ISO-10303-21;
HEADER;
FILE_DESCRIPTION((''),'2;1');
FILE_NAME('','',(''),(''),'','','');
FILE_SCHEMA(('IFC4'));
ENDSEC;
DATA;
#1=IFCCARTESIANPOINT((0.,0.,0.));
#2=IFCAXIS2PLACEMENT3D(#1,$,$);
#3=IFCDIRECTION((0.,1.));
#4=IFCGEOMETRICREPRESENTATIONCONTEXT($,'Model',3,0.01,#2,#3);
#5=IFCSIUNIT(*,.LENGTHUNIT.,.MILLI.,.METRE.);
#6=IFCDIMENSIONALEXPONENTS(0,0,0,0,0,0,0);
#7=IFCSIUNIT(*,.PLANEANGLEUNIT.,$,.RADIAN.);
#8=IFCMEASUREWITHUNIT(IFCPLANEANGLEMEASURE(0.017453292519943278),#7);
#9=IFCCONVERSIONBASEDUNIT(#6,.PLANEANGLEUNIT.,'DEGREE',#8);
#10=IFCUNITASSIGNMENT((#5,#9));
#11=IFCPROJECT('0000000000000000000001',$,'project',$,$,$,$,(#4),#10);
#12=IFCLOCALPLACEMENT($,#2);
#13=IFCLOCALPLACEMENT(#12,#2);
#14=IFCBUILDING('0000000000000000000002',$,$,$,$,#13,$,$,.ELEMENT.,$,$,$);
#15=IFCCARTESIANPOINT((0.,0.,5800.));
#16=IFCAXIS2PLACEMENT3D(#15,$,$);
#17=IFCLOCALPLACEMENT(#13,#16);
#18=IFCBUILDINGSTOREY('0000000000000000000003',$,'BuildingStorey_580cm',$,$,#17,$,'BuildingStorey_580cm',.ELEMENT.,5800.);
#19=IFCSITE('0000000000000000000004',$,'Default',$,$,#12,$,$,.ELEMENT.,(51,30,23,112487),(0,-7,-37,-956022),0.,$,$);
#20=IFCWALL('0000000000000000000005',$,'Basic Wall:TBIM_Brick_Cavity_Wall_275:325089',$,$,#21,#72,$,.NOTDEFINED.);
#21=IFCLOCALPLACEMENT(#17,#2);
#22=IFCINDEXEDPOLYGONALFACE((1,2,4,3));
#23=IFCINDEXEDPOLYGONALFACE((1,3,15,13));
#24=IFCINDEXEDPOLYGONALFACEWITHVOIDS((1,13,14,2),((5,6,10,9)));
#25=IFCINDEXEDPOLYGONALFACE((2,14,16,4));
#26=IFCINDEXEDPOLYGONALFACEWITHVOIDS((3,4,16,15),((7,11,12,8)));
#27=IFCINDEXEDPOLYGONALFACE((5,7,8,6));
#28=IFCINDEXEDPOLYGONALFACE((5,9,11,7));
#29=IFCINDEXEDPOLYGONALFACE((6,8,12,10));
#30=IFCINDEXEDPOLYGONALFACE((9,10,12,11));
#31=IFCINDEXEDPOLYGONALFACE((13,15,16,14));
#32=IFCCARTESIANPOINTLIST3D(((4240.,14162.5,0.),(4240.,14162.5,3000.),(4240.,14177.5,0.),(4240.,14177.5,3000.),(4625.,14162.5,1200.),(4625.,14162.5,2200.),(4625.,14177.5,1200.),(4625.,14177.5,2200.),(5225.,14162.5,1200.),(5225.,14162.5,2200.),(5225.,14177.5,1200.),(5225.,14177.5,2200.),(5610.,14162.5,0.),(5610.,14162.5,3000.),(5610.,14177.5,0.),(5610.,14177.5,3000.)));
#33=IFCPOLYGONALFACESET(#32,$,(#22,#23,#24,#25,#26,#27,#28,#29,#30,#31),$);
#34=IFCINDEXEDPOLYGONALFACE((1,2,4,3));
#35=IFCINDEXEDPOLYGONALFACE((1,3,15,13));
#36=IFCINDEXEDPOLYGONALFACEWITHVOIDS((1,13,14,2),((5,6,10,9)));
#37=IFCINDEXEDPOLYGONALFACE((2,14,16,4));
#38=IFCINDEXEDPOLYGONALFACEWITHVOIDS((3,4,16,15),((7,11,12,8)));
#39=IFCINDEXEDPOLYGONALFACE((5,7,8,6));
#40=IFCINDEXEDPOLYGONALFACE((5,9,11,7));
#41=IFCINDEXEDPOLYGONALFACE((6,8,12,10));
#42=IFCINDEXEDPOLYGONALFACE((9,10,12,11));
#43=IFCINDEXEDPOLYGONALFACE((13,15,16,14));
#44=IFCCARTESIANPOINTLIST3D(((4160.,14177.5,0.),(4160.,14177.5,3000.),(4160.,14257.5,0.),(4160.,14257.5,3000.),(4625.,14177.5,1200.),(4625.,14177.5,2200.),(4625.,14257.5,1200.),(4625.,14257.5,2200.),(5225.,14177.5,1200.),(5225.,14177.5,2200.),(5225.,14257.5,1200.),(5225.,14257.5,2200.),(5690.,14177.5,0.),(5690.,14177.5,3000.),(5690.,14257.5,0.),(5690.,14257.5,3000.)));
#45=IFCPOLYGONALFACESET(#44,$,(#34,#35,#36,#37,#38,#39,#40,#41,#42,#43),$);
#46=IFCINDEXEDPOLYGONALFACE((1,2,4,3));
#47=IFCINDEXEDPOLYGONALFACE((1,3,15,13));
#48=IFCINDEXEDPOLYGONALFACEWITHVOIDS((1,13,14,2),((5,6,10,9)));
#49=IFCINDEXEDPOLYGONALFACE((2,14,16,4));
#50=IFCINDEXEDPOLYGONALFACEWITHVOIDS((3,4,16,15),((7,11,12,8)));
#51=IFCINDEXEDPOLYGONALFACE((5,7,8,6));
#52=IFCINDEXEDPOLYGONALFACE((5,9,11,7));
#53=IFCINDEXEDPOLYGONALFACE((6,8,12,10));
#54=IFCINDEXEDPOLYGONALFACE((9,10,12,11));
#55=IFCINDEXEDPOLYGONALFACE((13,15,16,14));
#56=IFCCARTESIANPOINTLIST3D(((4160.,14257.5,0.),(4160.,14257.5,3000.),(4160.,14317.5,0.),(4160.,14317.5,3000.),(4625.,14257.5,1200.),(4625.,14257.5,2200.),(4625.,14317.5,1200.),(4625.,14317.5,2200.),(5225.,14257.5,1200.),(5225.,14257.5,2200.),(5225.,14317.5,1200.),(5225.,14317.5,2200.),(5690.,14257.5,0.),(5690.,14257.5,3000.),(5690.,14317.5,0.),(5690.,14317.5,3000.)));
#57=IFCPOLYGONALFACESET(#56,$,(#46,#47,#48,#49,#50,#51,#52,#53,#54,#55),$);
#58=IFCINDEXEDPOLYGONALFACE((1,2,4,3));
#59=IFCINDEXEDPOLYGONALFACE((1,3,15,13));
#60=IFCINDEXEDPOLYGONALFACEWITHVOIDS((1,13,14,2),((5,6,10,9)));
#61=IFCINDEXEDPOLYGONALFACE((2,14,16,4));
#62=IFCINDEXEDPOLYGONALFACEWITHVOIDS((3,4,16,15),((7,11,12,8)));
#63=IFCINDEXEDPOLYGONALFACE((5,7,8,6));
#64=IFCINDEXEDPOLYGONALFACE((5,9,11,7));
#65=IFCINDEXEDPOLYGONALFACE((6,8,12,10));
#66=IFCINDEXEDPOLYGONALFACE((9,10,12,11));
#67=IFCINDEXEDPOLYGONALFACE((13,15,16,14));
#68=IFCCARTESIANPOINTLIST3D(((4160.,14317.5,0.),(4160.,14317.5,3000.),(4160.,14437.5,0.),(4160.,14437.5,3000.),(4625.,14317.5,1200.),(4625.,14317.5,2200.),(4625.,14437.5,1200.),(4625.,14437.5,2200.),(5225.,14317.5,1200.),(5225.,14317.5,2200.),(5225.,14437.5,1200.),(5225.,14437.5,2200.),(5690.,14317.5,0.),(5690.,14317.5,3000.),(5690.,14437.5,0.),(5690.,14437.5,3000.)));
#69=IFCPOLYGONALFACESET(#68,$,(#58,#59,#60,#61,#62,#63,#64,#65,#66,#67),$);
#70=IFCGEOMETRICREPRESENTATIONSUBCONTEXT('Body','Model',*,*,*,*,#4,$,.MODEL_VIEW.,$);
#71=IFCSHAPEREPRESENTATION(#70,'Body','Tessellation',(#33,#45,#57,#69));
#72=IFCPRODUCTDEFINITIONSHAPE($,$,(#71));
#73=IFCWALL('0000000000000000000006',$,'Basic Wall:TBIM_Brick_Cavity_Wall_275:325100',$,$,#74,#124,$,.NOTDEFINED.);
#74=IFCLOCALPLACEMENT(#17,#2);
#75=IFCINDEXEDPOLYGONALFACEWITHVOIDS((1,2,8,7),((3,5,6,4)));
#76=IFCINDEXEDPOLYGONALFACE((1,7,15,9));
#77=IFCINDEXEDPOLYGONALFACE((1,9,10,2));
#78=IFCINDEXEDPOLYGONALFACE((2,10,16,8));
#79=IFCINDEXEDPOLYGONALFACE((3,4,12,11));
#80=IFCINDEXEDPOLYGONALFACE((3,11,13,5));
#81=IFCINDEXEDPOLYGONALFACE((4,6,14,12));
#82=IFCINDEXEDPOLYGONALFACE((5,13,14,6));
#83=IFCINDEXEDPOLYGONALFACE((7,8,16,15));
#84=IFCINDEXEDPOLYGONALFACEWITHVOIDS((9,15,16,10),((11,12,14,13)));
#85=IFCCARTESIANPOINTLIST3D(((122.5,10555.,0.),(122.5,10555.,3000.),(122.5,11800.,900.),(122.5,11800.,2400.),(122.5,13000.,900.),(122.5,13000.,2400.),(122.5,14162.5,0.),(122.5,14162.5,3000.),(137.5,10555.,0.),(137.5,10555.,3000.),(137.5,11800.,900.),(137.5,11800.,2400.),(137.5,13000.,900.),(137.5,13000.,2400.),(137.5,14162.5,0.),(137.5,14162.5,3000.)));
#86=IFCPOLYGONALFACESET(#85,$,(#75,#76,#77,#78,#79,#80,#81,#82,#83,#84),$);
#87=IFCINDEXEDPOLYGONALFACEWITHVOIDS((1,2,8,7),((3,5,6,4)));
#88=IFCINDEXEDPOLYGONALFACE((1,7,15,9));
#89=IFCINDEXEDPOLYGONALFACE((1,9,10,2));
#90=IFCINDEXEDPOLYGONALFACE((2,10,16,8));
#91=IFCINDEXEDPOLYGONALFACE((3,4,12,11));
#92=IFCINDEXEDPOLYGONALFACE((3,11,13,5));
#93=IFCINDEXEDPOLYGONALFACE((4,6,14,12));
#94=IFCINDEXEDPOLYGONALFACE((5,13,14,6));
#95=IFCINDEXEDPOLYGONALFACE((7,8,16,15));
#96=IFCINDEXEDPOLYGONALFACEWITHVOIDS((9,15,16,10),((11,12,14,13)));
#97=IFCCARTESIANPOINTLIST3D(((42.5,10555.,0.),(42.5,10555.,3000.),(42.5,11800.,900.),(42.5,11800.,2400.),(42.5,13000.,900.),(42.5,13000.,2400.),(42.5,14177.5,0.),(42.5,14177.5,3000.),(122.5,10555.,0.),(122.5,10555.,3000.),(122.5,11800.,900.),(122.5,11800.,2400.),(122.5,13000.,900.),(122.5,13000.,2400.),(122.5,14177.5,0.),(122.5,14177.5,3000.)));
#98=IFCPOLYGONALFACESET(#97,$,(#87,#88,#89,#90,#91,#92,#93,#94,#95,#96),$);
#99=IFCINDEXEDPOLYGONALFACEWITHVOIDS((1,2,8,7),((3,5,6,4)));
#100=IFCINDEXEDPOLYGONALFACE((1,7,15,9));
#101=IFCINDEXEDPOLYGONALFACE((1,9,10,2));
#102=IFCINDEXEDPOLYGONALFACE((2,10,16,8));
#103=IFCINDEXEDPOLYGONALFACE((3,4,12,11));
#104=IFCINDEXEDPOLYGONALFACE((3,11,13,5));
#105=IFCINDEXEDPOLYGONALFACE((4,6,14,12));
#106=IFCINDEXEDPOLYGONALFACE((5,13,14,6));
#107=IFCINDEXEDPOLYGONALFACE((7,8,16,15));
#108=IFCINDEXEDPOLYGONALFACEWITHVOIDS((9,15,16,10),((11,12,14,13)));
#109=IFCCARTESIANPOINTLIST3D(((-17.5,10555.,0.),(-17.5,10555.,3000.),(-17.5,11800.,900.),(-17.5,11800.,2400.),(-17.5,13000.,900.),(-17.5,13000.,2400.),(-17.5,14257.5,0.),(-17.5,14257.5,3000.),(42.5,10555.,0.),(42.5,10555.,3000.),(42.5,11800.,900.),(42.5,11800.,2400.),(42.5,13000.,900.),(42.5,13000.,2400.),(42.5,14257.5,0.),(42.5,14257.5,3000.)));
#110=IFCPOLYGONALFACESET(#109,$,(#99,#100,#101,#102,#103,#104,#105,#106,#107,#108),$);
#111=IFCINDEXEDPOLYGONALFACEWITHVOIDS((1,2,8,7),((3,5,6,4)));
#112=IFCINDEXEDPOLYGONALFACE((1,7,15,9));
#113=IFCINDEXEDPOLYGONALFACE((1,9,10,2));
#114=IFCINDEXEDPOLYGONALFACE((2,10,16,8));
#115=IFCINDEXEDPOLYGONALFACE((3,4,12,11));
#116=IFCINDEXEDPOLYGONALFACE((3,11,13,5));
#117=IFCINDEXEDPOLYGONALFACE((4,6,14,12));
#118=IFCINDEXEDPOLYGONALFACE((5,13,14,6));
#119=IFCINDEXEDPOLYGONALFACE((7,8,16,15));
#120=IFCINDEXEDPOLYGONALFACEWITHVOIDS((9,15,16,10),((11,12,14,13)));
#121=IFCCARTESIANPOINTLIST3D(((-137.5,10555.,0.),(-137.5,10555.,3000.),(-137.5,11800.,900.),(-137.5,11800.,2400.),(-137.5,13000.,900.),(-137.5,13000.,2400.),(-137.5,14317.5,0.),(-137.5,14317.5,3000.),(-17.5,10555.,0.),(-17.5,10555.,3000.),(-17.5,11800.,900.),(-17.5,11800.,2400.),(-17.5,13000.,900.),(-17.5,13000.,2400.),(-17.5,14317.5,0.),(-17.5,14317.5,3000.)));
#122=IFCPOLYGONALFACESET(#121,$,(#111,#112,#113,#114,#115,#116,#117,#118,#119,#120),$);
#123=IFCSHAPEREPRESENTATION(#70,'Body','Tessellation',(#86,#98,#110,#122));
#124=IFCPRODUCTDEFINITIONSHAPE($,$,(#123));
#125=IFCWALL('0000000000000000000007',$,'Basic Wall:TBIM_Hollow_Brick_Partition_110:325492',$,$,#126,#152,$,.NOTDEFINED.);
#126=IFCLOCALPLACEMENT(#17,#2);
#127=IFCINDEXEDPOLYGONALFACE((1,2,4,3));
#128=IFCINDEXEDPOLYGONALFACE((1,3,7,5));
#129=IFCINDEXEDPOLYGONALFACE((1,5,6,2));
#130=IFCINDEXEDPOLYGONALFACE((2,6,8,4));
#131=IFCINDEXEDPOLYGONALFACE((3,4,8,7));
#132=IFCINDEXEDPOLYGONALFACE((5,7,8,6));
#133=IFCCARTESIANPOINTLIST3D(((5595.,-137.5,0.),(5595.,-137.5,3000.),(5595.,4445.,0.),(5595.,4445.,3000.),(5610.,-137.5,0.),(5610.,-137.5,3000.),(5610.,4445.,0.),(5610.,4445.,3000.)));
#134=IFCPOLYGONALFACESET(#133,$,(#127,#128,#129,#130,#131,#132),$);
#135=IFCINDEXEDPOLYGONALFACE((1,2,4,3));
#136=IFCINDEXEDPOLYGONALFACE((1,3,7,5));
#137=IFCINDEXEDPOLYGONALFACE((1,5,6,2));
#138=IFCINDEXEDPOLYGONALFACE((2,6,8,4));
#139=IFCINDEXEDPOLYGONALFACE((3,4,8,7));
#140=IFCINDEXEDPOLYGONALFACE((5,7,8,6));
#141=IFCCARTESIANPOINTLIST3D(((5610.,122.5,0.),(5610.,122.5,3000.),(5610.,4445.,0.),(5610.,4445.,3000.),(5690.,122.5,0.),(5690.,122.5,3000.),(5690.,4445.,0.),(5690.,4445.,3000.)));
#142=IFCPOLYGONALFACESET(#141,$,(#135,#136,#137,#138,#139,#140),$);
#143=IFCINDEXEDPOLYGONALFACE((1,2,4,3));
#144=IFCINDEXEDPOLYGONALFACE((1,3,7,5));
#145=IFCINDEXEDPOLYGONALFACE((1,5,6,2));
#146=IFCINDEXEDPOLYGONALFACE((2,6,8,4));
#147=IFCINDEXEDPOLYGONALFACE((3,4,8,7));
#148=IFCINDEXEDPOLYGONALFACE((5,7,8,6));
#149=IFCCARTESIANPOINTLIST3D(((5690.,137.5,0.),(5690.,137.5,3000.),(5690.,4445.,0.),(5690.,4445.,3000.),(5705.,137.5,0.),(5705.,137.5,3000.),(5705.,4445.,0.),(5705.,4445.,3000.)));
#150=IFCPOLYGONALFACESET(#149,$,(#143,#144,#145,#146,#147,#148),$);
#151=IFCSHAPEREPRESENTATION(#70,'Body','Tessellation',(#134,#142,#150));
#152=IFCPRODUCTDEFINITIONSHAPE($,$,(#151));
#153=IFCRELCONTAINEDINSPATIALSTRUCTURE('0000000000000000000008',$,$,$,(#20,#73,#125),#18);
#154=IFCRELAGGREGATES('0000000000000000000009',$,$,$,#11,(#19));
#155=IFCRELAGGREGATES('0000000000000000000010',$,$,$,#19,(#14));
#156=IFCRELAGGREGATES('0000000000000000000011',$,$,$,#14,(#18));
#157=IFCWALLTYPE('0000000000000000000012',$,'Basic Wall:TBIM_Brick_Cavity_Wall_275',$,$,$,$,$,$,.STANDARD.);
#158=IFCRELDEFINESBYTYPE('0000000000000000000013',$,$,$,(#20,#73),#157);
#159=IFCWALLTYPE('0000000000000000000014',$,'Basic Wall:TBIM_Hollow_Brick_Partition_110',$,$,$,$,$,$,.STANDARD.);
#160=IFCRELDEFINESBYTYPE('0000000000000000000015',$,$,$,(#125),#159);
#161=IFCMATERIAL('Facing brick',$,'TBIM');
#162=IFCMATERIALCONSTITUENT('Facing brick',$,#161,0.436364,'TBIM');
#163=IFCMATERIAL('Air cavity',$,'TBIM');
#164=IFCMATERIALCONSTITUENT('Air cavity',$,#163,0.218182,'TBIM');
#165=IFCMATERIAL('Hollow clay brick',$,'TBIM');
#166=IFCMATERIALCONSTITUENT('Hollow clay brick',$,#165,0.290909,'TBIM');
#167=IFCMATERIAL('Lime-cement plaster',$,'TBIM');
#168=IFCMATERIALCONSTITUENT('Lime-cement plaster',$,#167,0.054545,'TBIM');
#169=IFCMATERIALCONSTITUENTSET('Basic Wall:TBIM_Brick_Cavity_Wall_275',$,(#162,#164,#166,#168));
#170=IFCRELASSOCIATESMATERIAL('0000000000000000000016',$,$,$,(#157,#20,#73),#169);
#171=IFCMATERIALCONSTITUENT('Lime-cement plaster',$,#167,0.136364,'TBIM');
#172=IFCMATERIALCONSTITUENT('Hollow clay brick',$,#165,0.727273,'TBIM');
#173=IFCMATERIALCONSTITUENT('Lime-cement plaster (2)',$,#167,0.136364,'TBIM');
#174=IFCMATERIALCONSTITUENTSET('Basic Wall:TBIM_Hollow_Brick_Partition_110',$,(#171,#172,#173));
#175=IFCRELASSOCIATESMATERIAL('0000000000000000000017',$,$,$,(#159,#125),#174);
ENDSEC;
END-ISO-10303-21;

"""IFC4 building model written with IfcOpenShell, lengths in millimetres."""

from ifc_helpers import new_model, entity, si_unit, converted_unit, direction, frame, origin, place, context, subcontext, project, spatial, indexed_curve, outline, extrude, material, constituent, constituent_set, type_object, element, save


model = new_model("IFC4")

# Units and contexts
model_context = context("Model", 3, precision=0.01, world=origin(), true_north=direction((0.0, 1.0)))
body_context = subcontext(model_context, "Body", "Model", "MODEL_VIEW")
ifc_project = project(units=[si_unit("LENGTHUNIT", "METRE", prefix="MILLI"), converted_unit("PLANEANGLEUNIT", "DEGREE", entity("IfcPlaneAngleMeasure", 0.017453292519943278), si_unit("PLANEANGLEUNIT", "RADIAN"), dimensions=[0, 0, 0, 0, 0, 0, 0])], contexts=[model_context])

# Site, building, storey
site_placement = place(None, origin())
site = spatial("IfcSite", under=ifc_project, at=site_placement, Name="Default", CompositionType="ELEMENT", RefLatitude=(51, 30, 23, 112487), RefLongitude=(0, -7, -37, -956022), RefElevation=0.0)
building_placement = place(site_placement, origin())
building = spatial("IfcBuilding", under=site, at=building_placement, CompositionType="ELEMENT")
storey_placement = place(building_placement, frame((0.0, 0.0, 5800.0)))
storey = spatial("IfcBuildingStorey", under=building, at=storey_placement, Name="BuildingStorey_580cm", LongName="BuildingStorey_580cm", CompositionType="ELEMENT", Elevation=5800.0)

# Shared definitions
ifc_material_1 = material(Name="Lime-cement plaster", Category="TBIM")

# Walls, openings
ifc_material_2 = material(Name="Facing brick", Category="TBIM")
ifc_constituent_1 = constituent(ifc_material_2, Name="Facing brick", Category="TBIM", fraction=0.436364)
ifc_material_3 = material(Name="Air cavity", Category="TBIM")
ifc_constituent_2 = constituent(ifc_material_3, Name="Air cavity", Category="TBIM", fraction=0.218182)
ifc_material_4 = material(Name="Hollow clay brick", Category="TBIM")
ifc_constituent_3 = constituent(ifc_material_4, Name="Hollow clay brick", Category="TBIM", fraction=0.290909)
ifc_constituent_4 = constituent(ifc_material_1, Name="Lime-cement plaster", Category="TBIM", fraction=0.054545)
ifc_constituent_set_1 = constituent_set(constituents=[ifc_constituent_1, ifc_constituent_2, ifc_constituent_3, ifc_constituent_4], Name="Basic Wall:TBIM_Brick_Cavity_Wall_275")
wall_type_1 = type_object("IfcWallType", Name="Basic Wall:TBIM_Brick_Cavity_Wall_275", PredefinedType="STANDARD", material=ifc_constituent_set_1)
wall_1_placement = place(storey_placement, frame((5705.0, 14300.0, 0.0), z_axis=(0.0, 0.0, 1.0), x_axis=(-1.0, 0.0, 0.0)))
wall_1 = element("IfcWall", 1, at=wall_1_placement, inside=storey, type_object=wall_type_1, material=ifc_constituent_set_1, Name="Basic Wall:TBIM_Brick_Cavity_Wall_275:325089", PredefinedType="NOTDEFINED", context=body_context, shape_type="SweptSolid", body=[
    extrude(outline(indexed_curve([(-685.0, -1500.0), (-670.0, -1500.0), (670.0, -1500.0), (685.0, -1500.0), (685.0, 1500.0), (670.0, 1500.0), (-670.0, 1500.0), (-685.0, 1500.0), (-685.0, -1500.0)], self_intersect=False), holes=[indexed_curve([(-300.0, 700.0), (300.0, 700.0), (300.0, -300.0), (-300.0, -300.0), (-300.0, 700.0)], self_intersect=False)]), frame((780.0, 137.5, 1500.0), z_axis=(0.0, -1.0, 0.0), x_axis=(1.0, 0.0, 0.0)), (0.0, 0.0, 1.0), 15.0),
    extrude(outline(indexed_curve([(-1500.0, -765.0), (1500.0, -765.0), (1500.0, 765.0), (-1500.0, 765.0), (-1500.0, -765.0)], self_intersect=False), holes=[indexed_curve([(700.0, 300.0), (700.0, -300.0), (-300.0, -300.0), (-300.0, 300.0), (700.0, 300.0)], self_intersect=False)]), frame((780.0, 122.5, 1500.0), z_axis=(0.0, -1.0, 0.0), x_axis=(0.0, 0.0, 1.0)), (0.0, 0.0, 1.0), 80.0),
    extrude(outline(indexed_curve([(-1500.0, -765.0), (1500.0, -765.0), (1500.0, 765.0), (-1500.0, 765.0), (-1500.0, -765.0)], self_intersect=False), holes=[indexed_curve([(700.0, 300.0), (700.0, -300.0), (-300.0, -300.0), (-300.0, 300.0), (700.0, 300.0)], self_intersect=False)]), frame((780.0, 42.5, 1500.0), z_axis=(0.0, -1.0, 0.0), x_axis=(0.0, 0.0, 1.0)), (0.0, 0.0, 1.0), 60.0),
    extrude(outline(indexed_curve([(-1500.0, -765.0), (1500.0, -765.0), (1500.0, 765.0), (-1500.0, 765.0), (-1500.0, -765.0)], self_intersect=False), holes=[indexed_curve([(700.0, 300.0), (700.0, -300.0), (-300.0, -300.0), (-300.0, 300.0), (700.0, 300.0)], self_intersect=False)]), frame((780.0, -17.5, 1500.0), z_axis=(0.0, -1.0, 0.0), x_axis=(0.0, 0.0, 1.0)), (0.0, 0.0, 1.0), 120.0),
])
opening_1_placement = place(wall_1_placement, frame((480.0, -137.5, 1200.0)))
element("IfcOpeningElement", 2, at=opening_1_placement, cuts=wall_1, PredefinedType="OPENING", context=body_context, shape_type="SweptSolid", body=[
    extrude(outline(indexed_curve([(1000.0, 0.0), (1000.0, 600.0), (0.0, 600.0), (0.0, 0.0), (1000.0, 0.0)], self_intersect=False)), frame((0.0, 0.0, 0.0), z_axis=(0.0, 1.0, 0.0), x_axis=(0.0, 0.0, 1.0)), (0.0, 0.0, 1.0), 275.0),
])
wall_2_placement = place(storey_placement, frame((0.0, 10555.0, 0.0), z_axis=(0.0, 0.0, 1.0), x_axis=(0.0, 1.0, 0.0)))
wall_2 = element("IfcWall", 3, at=wall_2_placement, inside=storey, type_object=wall_type_1, material=ifc_constituent_set_1, Name="Basic Wall:TBIM_Brick_Cavity_Wall_275:325100", PredefinedType="NOTDEFINED", context=body_context, shape_type="SweptSolid", body=[
    extrude(outline(indexed_curve([(-1500.0, -1803.7), (1500.0, -1803.8), (1500.0, 1803.7), (-1500.0, 1803.7), (-1500.0, -1803.7)], self_intersect=False), holes=[indexed_curve([(900.0, 558.8), (900.0, -641.2), (-600.0, -641.2), (-600.0, 558.8), (900.0, 558.8)], self_intersect=False)]), frame((1803.7, -122.5, 1500.0), z_axis=(0.0, -1.0, 0.0), x_axis=(0.0, 0.0, 1.0)), (0.0, 0.0, 1.0), 15.0),
    extrude(outline(indexed_curve([(-1500.0, -1811.2), (1500.0, -1811.2), (1500.0, 1811.2), (-1500.0, 1811.2), (-1500.0, -1811.2)], self_intersect=False), holes=[indexed_curve([(900.0, 566.3), (900.0, -633.7), (-600.0, -633.7), (-600.0, 566.3), (900.0, 566.3)], self_intersect=False)]), frame((1811.2, -42.5, 1500.0), z_axis=(0.0, -1.0, 0.0), x_axis=(0.0, 0.0, 1.0)), (0.0, 0.0, 1.0), 80.0),
    extrude(outline(indexed_curve([(-1500.0, -1851.2), (1500.0, -1851.2), (1500.0, 1851.2), (-1500.0, 1851.2), (-1500.0, -1851.2)], self_intersect=False), holes=[indexed_curve([(900.0, 606.3), (900.0, -593.7), (-600.0, -593.7), (-600.0, 606.3), (900.0, 606.3)], self_intersect=False)]), frame((1851.2, 17.5, 1500.0), z_axis=(0.0, -1.0, 0.0), x_axis=(0.0, 0.0, 1.0)), (0.0, 0.0, 1.0), 60.0),
    extrude(outline(indexed_curve([(-1881.2, -1500.0), (1881.2, -1500.0), (1881.2, 1500.0), (-1881.2, 1500.0), (-1881.2, -1500.0)], self_intersect=False), holes=[indexed_curve([(-636.3, 900.0), (563.7, 900.0), (563.7, -600.0), (-636.3, -600.0), (-636.3, 900.0)], self_intersect=False)]), frame((1881.2, 137.5, 1500.0), z_axis=(0.0, -1.0, 0.0), x_axis=(1.0, 0.0, 0.0)), (0.0, 0.0, 1.0), 120.0),
])
opening_2_placement = place(wall_2_placement, frame((1245.0, -137.5, 900.0)))
element("IfcOpeningElement", 4, at=opening_2_placement, cuts=wall_2, PredefinedType="OPENING", context=body_context, shape_type="SweptSolid", body=[
    extrude(outline(indexed_curve([(1500.0, 0.0), (1500.0, 1200.0), (0.0, 1200.0), (0.0, 0.0), (1500.0, 0.0)], self_intersect=False)), frame((0.0, 0.0, 0.0), z_axis=(0.0, 1.0, 0.0), x_axis=(0.0, 0.0, 1.0)), (0.0, 0.0, 1.0), 275.0),
])

# Wall
ifc_constituent_5 = constituent(ifc_material_1, Name="Lime-cement plaster", Category="TBIM", fraction=0.136364)
ifc_constituent_6 = constituent(ifc_material_4, Name="Hollow clay brick", Category="TBIM", fraction=0.727273)
ifc_constituent_7 = constituent(ifc_material_1, Name="Lime-cement plaster (2)", Category="TBIM", fraction=0.136364)
ifc_constituent_set_2 = constituent_set(constituents=[ifc_constituent_5, ifc_constituent_6, ifc_constituent_7], Name="Basic Wall:TBIM_Hollow_Brick_Partition_110")
wall_type_2 = type_object("IfcWallType", Name="Basic Wall:TBIM_Hollow_Brick_Partition_110", PredefinedType="STANDARD", material=ifc_constituent_set_2)
wall_3_placement = place(storey_placement, frame((5650.0, 137.5, 0.0), z_axis=(0.0, 0.0, 1.0), x_axis=(0.0, 1.0, 0.0)))
element("IfcWall", 5, at=wall_3_placement, inside=storey, type_object=wall_type_2, material=ifc_constituent_set_2, Name="Basic Wall:TBIM_Hollow_Brick_Partition_110:325492", PredefinedType="NOTDEFINED", context=body_context, shape_type="SweptSolid", body=[
    extrude(outline(indexed_curve([(-7.5, -2291.2), (7.5, -2291.2), (7.5, 2291.2), (-7.5, 2291.2), (-7.5, -2291.2)], self_intersect=False)), frame((2016.2, 47.5, 0.0), z_axis=(0.0, 0.0, 1.0), x_axis=(0.0, -1.0, 0.0)), (0.0, 0.0, 1.0), 3000.0),
    extrude(outline(indexed_curve([(-2161.2, -40.0), (2161.2, -40.0), (2161.2, 40.0), (-2161.3, 40.0), (-2161.2, -40.0)], self_intersect=False)), frame((2146.2, 0.0, 0.0)), (0.0, 0.0, 1.0), 3000.0),
    extrude(outline(indexed_curve([(-7.5, -2153.8), (7.5, -2153.8), (7.5, 2153.8), (-7.5, 2153.8), (-7.5, -2153.8)], self_intersect=False)), frame((2153.8, -47.5, 0.0), z_axis=(0.0, 0.0, 1.0), x_axis=(0.0, 1.0, 0.0)), (0.0, 0.0, 1.0), 3000.0),
])

save(model, "model.ifc")
